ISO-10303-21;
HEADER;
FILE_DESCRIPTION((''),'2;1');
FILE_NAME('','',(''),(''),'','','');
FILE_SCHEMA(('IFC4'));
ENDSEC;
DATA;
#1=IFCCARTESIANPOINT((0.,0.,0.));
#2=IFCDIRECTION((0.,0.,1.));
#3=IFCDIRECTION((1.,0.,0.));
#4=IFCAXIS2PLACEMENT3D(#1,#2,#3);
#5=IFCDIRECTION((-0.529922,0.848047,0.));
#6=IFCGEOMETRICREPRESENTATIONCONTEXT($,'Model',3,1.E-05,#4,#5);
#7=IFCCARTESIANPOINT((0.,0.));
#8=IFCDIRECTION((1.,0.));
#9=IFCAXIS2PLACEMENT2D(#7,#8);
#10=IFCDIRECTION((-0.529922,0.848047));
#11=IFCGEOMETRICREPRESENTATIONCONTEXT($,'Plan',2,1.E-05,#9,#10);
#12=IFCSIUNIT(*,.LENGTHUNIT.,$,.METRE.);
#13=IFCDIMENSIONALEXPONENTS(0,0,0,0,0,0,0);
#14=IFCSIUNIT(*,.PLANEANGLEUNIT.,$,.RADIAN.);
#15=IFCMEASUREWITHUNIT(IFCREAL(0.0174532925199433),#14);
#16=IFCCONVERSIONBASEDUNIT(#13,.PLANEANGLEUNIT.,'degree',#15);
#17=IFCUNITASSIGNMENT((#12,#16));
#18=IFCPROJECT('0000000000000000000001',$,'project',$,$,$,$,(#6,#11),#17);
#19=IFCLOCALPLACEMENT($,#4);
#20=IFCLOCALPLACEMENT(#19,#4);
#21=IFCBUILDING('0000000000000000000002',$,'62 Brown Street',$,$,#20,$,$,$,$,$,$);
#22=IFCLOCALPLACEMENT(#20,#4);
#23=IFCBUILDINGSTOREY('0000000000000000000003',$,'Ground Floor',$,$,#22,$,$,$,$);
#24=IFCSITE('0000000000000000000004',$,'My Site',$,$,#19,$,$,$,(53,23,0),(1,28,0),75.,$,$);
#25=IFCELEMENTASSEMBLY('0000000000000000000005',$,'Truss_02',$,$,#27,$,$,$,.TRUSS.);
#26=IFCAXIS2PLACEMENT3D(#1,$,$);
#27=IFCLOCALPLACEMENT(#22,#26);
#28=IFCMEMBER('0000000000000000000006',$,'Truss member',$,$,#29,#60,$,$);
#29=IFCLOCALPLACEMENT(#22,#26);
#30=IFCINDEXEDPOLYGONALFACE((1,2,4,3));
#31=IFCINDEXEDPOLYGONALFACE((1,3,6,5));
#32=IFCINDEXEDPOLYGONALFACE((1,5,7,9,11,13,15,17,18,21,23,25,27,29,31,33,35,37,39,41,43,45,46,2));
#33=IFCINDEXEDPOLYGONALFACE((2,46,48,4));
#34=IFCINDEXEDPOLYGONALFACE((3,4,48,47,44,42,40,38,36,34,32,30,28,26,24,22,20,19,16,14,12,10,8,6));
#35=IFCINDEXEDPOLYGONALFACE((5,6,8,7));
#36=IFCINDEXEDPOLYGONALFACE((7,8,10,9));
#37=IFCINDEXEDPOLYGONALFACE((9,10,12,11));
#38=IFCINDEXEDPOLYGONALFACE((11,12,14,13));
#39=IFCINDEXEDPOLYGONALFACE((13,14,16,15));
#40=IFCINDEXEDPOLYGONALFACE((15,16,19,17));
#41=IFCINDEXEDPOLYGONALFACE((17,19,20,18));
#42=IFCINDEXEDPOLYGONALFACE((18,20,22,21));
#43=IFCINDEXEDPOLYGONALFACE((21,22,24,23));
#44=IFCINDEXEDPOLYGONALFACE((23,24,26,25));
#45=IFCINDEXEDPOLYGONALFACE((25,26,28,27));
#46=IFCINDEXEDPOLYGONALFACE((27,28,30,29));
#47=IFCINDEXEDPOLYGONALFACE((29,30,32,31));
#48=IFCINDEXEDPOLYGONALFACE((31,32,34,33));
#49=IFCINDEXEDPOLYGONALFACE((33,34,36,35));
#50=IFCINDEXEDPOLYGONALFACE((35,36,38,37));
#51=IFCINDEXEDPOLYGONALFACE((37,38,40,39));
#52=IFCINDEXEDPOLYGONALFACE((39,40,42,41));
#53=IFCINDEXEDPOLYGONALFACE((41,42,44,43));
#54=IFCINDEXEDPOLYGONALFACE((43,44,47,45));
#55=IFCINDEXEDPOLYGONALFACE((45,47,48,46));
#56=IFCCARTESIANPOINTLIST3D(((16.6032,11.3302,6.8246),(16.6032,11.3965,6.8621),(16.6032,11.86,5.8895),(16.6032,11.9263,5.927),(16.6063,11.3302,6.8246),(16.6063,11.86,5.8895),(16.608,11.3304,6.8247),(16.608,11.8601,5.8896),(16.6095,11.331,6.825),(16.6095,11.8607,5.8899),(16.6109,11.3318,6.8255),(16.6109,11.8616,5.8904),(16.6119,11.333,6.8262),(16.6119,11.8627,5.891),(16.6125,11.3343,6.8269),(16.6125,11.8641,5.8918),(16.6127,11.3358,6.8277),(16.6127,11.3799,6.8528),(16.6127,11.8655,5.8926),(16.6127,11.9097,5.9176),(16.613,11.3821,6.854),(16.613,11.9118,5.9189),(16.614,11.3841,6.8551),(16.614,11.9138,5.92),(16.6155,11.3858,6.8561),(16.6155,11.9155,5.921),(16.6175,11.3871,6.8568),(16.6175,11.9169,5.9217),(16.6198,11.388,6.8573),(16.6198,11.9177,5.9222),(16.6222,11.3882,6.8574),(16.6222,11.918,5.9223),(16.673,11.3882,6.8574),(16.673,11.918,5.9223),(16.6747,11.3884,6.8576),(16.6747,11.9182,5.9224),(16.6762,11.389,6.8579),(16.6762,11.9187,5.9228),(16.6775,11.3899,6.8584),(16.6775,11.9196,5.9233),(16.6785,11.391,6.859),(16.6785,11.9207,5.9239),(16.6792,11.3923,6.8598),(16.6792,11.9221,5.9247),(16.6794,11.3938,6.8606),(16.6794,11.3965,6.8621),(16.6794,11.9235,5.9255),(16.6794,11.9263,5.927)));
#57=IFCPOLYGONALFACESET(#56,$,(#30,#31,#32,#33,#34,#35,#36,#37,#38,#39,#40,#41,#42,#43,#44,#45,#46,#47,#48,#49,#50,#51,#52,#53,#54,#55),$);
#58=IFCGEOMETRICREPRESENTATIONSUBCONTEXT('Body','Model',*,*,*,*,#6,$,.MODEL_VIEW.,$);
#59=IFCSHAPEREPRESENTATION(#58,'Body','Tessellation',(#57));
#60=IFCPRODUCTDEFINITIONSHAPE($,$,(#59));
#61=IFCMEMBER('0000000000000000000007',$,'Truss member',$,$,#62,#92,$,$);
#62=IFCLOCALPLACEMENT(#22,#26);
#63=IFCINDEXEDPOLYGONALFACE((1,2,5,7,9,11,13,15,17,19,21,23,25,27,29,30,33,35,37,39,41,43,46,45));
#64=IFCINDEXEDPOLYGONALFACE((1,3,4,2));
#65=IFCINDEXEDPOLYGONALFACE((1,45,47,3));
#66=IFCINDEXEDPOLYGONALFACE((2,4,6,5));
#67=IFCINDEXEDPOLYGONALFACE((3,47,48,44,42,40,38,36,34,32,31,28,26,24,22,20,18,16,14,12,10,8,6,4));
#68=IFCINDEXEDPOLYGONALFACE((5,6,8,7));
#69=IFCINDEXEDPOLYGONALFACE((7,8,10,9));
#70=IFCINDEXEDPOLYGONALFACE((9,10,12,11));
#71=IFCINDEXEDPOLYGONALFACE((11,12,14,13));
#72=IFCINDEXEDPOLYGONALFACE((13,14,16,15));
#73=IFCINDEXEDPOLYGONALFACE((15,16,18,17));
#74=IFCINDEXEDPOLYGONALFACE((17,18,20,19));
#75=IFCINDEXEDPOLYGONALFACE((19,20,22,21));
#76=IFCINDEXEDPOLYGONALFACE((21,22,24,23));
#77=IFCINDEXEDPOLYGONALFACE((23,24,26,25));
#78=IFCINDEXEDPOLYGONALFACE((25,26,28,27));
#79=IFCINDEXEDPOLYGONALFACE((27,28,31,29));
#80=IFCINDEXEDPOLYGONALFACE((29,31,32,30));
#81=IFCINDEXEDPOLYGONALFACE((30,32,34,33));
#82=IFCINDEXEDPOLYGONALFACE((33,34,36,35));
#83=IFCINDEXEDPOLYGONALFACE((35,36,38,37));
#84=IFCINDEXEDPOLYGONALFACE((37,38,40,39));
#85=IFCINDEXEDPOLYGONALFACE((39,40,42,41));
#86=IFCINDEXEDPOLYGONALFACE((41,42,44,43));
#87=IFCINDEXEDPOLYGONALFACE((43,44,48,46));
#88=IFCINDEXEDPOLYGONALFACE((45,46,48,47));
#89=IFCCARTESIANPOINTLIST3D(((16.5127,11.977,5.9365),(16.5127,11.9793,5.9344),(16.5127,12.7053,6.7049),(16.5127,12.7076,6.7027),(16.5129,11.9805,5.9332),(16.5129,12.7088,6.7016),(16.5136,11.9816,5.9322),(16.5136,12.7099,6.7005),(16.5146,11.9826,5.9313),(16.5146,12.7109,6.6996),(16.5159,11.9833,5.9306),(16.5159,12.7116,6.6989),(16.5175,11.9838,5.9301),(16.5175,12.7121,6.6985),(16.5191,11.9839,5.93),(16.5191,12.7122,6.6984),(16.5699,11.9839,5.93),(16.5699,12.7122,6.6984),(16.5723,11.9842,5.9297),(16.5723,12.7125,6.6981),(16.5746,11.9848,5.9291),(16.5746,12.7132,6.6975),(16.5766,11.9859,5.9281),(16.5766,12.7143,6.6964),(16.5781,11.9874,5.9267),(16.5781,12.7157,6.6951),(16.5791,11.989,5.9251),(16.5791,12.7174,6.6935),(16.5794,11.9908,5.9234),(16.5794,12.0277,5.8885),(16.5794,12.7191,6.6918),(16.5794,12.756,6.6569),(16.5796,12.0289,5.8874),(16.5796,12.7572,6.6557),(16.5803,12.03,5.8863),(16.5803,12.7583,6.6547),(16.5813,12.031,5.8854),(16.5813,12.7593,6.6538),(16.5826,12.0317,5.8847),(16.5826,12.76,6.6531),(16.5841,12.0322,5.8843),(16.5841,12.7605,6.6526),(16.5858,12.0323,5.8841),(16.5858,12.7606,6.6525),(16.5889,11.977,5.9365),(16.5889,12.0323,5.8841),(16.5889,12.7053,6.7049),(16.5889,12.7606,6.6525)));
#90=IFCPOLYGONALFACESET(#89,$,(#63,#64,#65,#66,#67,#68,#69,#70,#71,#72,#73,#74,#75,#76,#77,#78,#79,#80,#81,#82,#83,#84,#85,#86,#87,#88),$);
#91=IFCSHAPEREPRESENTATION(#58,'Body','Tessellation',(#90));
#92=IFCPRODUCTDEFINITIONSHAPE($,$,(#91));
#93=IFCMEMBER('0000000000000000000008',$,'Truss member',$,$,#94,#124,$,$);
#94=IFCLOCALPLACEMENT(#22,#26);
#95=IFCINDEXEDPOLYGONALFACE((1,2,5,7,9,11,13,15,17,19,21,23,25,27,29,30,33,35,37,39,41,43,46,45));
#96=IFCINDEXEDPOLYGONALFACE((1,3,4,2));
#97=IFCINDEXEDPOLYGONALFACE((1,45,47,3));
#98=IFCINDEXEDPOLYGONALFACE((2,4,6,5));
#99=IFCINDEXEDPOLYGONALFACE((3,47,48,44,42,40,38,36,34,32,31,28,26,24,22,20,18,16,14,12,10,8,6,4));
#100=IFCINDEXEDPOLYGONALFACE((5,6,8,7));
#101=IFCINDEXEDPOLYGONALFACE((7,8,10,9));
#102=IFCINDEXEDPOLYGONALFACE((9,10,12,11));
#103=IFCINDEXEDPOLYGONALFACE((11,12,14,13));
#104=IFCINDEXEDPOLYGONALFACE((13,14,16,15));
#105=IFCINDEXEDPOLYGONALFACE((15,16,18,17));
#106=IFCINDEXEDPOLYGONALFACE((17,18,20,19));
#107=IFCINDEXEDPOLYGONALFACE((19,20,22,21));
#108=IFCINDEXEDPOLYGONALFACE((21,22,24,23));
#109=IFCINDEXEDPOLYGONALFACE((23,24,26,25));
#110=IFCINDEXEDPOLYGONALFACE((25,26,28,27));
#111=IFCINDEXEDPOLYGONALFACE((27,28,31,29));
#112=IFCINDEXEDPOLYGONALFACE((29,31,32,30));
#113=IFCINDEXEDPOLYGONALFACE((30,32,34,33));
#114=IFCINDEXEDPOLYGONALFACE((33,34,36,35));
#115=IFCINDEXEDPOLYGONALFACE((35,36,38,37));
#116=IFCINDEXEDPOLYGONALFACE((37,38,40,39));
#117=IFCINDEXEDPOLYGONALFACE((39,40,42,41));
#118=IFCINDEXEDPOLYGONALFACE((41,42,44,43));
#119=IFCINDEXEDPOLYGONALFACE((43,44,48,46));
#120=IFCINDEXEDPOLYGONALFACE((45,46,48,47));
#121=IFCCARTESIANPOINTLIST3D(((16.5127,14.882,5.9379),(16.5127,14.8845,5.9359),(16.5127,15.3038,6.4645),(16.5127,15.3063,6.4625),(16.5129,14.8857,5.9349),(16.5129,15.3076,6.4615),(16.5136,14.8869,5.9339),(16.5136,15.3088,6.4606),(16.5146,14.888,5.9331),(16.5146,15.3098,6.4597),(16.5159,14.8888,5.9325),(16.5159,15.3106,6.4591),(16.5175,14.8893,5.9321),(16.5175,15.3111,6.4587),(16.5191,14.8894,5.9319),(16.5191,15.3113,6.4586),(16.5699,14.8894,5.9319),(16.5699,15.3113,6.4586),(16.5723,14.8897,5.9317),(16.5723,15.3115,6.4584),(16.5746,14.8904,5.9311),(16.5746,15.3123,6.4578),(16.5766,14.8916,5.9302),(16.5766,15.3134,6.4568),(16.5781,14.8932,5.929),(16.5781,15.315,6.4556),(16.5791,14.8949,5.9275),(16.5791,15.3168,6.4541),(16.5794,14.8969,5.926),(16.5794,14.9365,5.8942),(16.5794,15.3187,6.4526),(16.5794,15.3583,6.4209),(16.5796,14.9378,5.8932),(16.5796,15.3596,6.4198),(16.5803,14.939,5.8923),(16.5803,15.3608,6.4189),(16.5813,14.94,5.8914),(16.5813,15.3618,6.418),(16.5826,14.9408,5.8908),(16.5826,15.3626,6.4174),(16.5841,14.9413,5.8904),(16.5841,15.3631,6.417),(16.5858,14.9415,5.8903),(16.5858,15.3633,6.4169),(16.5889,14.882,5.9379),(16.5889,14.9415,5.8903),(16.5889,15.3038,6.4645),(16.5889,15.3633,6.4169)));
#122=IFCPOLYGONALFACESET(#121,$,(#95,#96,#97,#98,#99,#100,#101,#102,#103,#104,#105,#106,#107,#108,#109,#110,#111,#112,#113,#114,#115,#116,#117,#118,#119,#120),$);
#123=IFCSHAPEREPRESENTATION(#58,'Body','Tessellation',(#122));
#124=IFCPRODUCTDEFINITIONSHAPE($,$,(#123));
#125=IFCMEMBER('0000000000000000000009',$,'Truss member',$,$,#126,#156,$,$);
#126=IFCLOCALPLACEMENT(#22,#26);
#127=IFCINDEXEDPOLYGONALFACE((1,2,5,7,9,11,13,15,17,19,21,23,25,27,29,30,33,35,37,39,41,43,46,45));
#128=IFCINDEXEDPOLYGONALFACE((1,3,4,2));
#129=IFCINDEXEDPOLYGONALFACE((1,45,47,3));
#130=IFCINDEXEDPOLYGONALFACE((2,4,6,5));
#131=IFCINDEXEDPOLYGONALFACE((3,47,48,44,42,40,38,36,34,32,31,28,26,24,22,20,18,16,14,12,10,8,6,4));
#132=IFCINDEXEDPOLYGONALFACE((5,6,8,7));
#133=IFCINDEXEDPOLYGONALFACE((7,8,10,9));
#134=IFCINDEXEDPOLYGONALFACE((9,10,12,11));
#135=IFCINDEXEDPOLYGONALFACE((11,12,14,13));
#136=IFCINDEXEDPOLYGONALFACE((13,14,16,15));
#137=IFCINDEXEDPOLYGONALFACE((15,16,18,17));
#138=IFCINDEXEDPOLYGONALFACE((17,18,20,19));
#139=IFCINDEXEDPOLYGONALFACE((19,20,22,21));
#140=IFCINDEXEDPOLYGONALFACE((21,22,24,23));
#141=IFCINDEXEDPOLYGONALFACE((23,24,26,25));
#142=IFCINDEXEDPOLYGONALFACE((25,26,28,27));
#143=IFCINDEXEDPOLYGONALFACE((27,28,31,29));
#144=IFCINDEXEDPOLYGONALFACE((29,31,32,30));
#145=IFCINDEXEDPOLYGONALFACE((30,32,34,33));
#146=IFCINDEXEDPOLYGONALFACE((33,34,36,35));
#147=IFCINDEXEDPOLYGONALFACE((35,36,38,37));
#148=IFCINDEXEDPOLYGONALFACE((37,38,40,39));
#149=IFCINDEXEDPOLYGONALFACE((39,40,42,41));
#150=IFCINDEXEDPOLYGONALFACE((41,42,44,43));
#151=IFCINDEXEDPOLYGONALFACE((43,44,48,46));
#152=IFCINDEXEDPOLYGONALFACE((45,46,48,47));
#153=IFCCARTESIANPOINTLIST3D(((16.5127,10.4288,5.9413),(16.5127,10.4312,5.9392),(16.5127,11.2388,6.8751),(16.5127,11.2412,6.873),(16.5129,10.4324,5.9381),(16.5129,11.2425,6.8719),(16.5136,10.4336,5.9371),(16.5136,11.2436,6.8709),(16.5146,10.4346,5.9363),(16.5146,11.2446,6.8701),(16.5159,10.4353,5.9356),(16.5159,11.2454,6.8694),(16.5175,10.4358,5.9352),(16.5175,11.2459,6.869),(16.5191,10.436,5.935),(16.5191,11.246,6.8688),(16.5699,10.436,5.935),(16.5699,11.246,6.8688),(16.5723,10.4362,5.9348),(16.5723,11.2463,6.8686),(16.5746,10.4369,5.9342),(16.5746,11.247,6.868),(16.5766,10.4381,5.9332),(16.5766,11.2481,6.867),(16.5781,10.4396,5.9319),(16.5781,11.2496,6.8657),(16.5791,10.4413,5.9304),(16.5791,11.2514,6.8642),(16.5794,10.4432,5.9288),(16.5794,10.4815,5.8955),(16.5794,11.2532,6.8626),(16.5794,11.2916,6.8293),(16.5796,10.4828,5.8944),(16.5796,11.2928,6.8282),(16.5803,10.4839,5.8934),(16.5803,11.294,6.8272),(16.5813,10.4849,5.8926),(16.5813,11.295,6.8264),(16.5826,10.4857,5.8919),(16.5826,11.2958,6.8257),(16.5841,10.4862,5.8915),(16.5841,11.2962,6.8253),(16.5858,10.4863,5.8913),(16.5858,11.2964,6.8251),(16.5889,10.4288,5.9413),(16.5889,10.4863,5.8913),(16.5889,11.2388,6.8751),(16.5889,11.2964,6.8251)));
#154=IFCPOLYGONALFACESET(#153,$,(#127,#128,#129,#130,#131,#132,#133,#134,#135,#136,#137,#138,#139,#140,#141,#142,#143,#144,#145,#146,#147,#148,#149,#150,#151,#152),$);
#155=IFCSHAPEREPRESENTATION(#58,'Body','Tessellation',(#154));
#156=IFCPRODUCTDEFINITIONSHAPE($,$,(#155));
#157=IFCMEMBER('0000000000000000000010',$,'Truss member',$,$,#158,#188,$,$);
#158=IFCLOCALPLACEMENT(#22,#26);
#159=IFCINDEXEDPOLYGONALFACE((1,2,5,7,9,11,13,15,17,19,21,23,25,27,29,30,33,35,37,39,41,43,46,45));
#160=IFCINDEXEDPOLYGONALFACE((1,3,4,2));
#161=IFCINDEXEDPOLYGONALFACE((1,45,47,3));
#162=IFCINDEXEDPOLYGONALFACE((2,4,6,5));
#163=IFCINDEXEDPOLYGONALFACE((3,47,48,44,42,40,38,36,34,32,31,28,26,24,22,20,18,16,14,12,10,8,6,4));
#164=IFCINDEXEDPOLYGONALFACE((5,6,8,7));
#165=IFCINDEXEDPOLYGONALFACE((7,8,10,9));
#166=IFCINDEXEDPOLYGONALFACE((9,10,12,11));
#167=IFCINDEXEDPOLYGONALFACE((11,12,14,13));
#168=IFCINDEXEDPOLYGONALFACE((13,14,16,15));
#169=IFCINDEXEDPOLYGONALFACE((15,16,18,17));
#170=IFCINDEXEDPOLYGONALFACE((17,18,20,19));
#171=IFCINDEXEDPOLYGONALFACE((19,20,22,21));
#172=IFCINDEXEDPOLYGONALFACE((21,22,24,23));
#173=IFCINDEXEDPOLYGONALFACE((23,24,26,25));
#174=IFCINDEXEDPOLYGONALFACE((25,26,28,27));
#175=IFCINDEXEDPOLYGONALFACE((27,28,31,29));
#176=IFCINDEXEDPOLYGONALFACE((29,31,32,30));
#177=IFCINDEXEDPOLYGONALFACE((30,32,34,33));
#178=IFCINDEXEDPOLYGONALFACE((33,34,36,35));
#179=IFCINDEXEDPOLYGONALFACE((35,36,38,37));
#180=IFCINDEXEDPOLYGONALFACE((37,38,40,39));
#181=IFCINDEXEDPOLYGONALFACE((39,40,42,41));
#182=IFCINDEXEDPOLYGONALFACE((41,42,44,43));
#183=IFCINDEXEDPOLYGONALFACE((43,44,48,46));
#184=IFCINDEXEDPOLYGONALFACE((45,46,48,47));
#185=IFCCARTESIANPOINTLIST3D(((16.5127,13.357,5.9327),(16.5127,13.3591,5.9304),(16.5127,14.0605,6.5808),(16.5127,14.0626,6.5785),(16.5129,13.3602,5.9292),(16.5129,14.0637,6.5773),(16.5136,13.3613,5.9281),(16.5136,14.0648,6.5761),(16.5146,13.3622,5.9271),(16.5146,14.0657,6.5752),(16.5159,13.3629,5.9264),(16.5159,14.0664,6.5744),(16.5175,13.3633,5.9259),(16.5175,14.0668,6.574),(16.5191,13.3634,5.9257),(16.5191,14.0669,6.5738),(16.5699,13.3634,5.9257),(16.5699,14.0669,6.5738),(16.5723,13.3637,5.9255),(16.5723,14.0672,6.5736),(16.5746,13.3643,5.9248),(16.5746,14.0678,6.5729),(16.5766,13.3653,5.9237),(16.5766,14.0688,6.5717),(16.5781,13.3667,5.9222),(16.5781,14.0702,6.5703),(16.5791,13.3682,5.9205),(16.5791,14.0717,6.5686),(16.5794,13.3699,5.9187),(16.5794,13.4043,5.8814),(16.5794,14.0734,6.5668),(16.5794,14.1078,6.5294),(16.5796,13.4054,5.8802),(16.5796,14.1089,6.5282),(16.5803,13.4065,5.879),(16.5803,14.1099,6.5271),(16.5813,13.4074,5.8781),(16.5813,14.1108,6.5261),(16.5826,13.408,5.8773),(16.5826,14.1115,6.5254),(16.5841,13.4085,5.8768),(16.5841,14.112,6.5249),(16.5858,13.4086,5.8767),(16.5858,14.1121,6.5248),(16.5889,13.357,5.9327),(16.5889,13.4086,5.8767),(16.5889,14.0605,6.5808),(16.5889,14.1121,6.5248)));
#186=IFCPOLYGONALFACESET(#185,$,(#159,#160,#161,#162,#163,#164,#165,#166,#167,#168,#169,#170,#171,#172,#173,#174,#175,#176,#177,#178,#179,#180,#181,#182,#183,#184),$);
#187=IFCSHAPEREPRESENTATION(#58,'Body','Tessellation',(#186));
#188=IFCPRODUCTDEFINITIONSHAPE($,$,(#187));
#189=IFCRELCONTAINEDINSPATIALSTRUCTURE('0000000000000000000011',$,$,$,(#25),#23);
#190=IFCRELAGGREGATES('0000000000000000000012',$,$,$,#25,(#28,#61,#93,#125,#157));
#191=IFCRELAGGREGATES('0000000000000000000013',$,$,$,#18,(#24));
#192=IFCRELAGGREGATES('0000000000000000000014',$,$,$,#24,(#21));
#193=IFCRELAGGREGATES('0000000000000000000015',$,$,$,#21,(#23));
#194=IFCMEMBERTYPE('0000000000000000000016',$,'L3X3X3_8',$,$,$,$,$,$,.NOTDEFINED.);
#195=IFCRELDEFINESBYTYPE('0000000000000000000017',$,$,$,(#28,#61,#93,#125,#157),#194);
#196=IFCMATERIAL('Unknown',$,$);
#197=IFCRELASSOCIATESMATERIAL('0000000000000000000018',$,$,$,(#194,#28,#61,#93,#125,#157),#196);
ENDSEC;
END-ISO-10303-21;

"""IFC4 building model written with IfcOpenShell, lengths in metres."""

from ifc_helpers import new_model, entity, si_unit, converted_unit, direction, frame, origin_with_axes, origin_2d_with_axis, place, context, subcontext, project, spatial, l_section, extrude, material, material_profile, profile_set, profile_usage, type_object, element, aggregate, save


model = new_model("IFC4")

# Units and contexts
model_context = context("Model", 3, precision=1e-05, world=origin_with_axes(), true_north=direction((-0.529922, 0.848047, 0.0)))
plan_context = context("Plan", 2, precision=1e-05, world=origin_2d_with_axis(), true_north=direction((-0.529922, 0.848047)))
body_context = subcontext(model_context, "Body", "Model", "MODEL_VIEW")
ifc_project = project(units=[si_unit("LENGTHUNIT", "METRE"), converted_unit("PLANEANGLEUNIT", "degree", entity("IfcReal", 0.0174532925199433), si_unit("PLANEANGLEUNIT", "RADIAN"), dimensions=[0, 0, 0, 0, 0, 0, 0])], contexts=[model_context, plan_context])

# Site, building, storey
site_placement = place(None, origin_with_axes())
site = spatial("IfcSite", under=ifc_project, at=site_placement, Name="My Site", RefLatitude=(53, 23, 0), RefLongitude=(1, 28, 0), RefElevation=75.0)
building_placement = place(site_placement, origin_with_axes())
building = spatial("IfcBuilding", under=site, at=building_placement, Name="62 Brown Street")
storey_placement = place(building_placement, origin_with_axes())
storey = spatial("IfcBuildingStorey", under=building, at=storey_placement, Name="Ground Floor")

# Element assembly, members
ifc_material_1 = material(Name="Unknown")
ifc_material_profile_1 = material_profile(ifc_material_1, l_section(Depth=0.0762, Width=0.0762, Thickness=0.0095, FilletRadius=0.0095, EdgeRadius=0.0064))
ifc_profile_set_1 = profile_set([ifc_material_profile_1])
member_type_1 = type_object("IfcMemberType", Name="L3X3X3_8", PredefinedType="NOTDEFINED", material=ifc_profile_set_1)
assembly_1_placement = place(storey_placement, frame((16.6032, 10.4288, 6.9738), z_axis=(0.0, 0.0, 1.0), x_axis=(1.0, 0.0, 0.0)))
assembly_1 = element("IfcElementAssembly", 1, at=assembly_1_placement, inside=storey, Name="Truss_02", PredefinedType="TRUSS")
ifc_profile_usage_1 = profile_usage(ifc_profile_set_1, cardinal=5)
member_1_placement = place(assembly_1_placement, frame((0.0381, 0.9346, -0.1304), z_axis=(0.0, 0.492899, -0.870086), x_axis=(1.0, 0.0, 0.0)))
member_1 = element("IfcMember", 2, at=member_1_placement, type_object=member_type_1, material=ifc_profile_usage_1, Name="Truss member", context=body_context, shape_type="SweptSolid", body=[
    extrude(l_section(Depth=0.0762, Width=0.0762, Thickness=0.0095, FilletRadius=0.0095, EdgeRadius=0.0064), origin_with_axes(), (0.0, 0.0, 1.0), 1.0747),
])
ifc_profile_usage_2 = profile_usage(ifc_profile_set_1, cardinal=5)
member_2_placement = place(assembly_1_placement, frame((-0.0524, 2.3042, -0.2951), z_axis=(0.000001, -0.687927, -0.72578), x_axis=(-1.0, 0.0, 0.0)))
member_2 = element("IfcMember", 3, at=member_2_placement, type_object=member_type_1, material=ifc_profile_usage_2, Name="Truss member", context=body_context, shape_type="SweptSolid", body=[
    extrude(l_section(Depth=0.0762, Width=0.0762, Thickness=0.0095, FilletRadius=0.0095, EdgeRadius=0.0064), origin_with_axes(), (0.0, 0.0, 1.0), 1.0587),
])
ifc_profile_usage_3 = profile_usage(ifc_profile_set_1, cardinal=5)
member_3_placement = place(assembly_1_placement, frame((-0.0524, 4.9048, -0.5331), z_axis=(0.000001, -0.625169, -0.780489), x_axis=(-1.0, -0.000001, 0.0)))
member_3 = element("IfcMember", 4, at=member_3_placement, type_object=member_type_1, material=ifc_profile_usage_3, Name="Truss member", context=body_context, shape_type="SweptSolid", body=[
    extrude(l_section(Depth=0.0762, Width=0.0762, Thickness=0.0095, FilletRadius=0.0095, EdgeRadius=0.0064), origin_with_axes(), (0.0, 0.0, 1.0), 0.6747),
])
ifc_profile_usage_4 = profile_usage(ifc_profile_set_1, cardinal=5)
member_4_placement = place(assembly_1_placement, frame((-0.0524, 0.8388, -0.1236), z_axis=(0.000001, -0.655276, -0.755389), x_axis=(-1.0, -0.000001, 0.0)))
member_4 = element("IfcMember", 5, at=member_4_placement, type_object=member_type_1, material=ifc_profile_usage_4, Name="Truss member", context=body_context, shape_type="SweptSolid", body=[
    extrude(l_section(Depth=0.0762, Width=0.0762, Thickness=0.0095, FilletRadius=0.0095, EdgeRadius=0.0064), origin_with_axes(), (0.0, 0.0, 1.0), 1.2362),
])
ifc_profile_usage_5 = profile_usage(ifc_profile_set_1, cardinal=5)
member_5_placement = place(assembly_1_placement, frame((-0.0524, 3.6575, -0.421), z_axis=(0.000001, -0.735484, -0.677542), x_axis=(-1.0, -0.000001, 0.0)))
member_5 = element("IfcMember", 6, at=member_5_placement, type_object=member_type_1, material=ifc_profile_usage_5, Name="Truss member", context=body_context, shape_type="SweptSolid", body=[
    extrude(l_section(Depth=0.0762, Width=0.0762, Thickness=0.0095, FilletRadius=0.0095, EdgeRadius=0.0064), origin_with_axes(), (0.0, 0.0, 1.0), 0.9565),
])

aggregate(assembly_1, [member_1, member_2, member_3, member_4, member_5])

save(model, "model.ifc")
